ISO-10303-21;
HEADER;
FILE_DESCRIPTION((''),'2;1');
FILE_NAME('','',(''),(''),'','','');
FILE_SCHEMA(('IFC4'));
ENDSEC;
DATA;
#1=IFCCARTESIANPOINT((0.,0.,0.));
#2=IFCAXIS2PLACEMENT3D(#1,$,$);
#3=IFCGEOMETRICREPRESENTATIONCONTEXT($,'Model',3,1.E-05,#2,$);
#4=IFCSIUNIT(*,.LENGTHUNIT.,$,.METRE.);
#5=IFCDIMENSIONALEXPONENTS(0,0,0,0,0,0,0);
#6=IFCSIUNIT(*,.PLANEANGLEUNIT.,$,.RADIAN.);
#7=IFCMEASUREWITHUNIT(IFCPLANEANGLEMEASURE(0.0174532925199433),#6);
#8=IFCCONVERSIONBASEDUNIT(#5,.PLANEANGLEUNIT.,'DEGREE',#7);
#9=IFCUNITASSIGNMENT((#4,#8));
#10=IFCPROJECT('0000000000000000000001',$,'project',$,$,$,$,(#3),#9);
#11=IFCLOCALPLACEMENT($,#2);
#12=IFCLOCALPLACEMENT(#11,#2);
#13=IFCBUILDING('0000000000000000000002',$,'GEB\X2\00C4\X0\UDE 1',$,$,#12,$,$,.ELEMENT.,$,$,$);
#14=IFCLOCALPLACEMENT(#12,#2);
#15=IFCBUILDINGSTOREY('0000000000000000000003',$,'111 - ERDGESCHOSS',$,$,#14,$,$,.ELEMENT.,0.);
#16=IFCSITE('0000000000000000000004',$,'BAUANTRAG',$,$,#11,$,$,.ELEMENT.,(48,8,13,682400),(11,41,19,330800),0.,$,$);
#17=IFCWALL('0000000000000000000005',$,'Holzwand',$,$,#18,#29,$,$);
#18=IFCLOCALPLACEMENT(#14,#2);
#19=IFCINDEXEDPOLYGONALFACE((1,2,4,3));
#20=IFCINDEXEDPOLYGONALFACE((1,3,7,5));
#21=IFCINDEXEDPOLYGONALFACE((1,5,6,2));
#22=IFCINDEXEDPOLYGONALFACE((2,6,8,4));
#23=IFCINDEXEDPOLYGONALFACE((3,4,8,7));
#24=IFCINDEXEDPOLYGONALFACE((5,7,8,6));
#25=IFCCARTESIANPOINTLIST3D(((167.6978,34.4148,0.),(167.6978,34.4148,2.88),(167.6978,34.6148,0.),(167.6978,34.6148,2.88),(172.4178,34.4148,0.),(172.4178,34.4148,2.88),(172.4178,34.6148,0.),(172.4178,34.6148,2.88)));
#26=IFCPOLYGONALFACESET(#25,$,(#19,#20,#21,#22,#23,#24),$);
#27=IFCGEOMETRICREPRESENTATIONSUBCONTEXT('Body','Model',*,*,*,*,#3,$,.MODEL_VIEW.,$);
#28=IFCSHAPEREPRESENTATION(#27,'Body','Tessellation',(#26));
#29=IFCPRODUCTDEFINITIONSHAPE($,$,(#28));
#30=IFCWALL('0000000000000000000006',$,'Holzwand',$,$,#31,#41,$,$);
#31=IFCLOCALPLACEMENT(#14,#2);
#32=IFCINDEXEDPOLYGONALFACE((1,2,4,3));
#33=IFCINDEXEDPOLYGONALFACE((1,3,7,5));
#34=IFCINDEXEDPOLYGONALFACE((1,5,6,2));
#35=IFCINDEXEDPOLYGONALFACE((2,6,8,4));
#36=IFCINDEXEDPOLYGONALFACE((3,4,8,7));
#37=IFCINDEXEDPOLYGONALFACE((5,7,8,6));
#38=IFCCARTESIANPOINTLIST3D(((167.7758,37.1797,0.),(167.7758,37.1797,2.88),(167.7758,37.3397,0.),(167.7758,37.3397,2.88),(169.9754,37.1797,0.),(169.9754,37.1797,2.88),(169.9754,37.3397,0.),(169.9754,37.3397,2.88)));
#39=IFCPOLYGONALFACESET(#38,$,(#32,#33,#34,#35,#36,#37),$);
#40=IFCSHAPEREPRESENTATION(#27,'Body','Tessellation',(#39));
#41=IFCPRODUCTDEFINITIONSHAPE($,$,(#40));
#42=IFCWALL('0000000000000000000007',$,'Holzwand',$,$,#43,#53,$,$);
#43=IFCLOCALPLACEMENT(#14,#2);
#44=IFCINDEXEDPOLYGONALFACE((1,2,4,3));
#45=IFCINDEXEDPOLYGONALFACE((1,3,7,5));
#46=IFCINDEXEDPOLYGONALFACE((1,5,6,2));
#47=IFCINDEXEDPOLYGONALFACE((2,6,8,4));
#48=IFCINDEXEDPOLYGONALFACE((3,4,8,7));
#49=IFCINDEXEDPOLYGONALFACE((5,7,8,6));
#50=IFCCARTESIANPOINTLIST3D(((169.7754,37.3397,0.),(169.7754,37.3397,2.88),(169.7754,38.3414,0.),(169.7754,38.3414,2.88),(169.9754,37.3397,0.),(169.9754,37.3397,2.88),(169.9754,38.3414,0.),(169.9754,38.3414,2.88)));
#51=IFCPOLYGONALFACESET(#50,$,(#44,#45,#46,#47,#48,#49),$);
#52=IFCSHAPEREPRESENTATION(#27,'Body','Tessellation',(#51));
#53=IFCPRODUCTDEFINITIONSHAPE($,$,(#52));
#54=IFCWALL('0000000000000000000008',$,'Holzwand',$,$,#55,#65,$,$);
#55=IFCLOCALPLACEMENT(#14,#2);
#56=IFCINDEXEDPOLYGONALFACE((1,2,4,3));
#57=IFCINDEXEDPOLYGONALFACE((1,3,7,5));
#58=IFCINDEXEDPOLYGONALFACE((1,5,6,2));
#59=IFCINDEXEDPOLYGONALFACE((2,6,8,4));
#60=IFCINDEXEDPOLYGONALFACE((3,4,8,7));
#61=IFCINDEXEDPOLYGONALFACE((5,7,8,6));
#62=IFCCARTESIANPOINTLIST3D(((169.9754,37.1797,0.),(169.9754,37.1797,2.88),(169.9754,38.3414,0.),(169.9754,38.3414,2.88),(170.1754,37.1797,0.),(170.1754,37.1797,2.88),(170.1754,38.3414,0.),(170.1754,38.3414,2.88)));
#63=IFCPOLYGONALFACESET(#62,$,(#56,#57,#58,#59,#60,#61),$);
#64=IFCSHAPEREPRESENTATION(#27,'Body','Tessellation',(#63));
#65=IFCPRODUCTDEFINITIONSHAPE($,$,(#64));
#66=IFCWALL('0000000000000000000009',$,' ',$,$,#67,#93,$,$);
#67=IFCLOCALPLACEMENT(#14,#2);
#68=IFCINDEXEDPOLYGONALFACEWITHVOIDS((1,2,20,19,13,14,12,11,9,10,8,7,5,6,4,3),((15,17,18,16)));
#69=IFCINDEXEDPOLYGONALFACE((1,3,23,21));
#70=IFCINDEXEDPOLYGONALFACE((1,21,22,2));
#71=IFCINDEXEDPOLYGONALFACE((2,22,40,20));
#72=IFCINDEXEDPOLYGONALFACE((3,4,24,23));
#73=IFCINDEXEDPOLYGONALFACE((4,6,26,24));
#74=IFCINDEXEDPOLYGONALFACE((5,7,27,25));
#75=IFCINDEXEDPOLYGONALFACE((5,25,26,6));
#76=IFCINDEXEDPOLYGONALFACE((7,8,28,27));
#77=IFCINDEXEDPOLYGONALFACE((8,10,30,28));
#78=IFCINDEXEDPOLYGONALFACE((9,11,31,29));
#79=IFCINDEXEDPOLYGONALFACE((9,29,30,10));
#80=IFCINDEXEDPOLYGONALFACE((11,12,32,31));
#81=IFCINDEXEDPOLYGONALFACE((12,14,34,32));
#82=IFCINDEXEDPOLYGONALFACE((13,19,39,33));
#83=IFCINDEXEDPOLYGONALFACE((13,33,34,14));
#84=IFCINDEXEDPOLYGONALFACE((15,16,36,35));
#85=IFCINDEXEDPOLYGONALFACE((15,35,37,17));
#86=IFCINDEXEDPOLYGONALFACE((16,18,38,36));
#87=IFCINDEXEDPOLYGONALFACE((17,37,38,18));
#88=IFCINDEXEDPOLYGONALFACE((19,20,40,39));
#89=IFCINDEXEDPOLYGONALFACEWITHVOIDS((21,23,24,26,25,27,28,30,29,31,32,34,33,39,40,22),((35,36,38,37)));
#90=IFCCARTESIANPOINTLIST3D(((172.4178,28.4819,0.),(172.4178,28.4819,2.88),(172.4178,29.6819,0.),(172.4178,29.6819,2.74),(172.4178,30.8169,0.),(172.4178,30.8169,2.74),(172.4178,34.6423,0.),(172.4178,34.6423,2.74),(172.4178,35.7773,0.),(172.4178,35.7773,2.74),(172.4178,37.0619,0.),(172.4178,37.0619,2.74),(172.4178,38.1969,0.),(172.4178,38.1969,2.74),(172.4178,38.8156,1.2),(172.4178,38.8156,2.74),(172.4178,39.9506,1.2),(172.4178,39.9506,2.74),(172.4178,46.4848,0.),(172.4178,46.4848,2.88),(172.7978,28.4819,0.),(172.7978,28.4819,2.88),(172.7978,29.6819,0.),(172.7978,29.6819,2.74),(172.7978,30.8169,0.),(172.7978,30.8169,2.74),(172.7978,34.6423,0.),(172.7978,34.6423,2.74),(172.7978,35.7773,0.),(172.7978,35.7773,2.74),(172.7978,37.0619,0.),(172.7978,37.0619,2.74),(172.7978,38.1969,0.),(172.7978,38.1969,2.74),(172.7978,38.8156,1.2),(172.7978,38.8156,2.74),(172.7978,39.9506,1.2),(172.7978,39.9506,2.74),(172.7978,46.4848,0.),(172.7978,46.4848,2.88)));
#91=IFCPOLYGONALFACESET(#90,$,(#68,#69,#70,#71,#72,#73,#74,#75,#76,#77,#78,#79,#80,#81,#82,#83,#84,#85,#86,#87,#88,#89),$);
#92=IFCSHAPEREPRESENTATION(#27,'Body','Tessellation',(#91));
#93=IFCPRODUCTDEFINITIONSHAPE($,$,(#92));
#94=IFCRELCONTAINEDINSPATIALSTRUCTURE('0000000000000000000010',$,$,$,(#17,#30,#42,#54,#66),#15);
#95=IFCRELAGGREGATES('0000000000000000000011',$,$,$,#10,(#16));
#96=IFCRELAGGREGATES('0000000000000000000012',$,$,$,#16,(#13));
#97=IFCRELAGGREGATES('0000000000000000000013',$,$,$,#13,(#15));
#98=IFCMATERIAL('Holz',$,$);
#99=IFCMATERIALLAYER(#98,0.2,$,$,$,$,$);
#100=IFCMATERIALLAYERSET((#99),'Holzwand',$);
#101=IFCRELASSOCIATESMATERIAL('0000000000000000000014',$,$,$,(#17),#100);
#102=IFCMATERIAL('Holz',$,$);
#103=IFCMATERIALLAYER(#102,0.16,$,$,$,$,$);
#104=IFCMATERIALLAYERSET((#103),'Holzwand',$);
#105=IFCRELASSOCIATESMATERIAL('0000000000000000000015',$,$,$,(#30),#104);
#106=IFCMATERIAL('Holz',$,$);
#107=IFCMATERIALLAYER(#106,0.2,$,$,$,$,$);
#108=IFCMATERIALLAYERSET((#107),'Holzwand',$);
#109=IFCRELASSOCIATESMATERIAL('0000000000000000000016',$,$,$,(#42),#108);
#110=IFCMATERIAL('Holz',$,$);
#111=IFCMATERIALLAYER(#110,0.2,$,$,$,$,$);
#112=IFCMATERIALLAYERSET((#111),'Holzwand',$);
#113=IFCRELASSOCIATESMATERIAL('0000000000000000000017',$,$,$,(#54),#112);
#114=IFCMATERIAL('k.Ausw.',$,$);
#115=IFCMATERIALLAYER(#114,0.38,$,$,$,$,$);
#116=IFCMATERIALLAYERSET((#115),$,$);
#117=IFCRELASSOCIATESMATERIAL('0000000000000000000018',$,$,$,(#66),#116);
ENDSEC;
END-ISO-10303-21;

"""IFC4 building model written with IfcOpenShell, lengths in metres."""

from ifc_helpers import new_model, entity, si_unit, converted_unit, frame, frame_2d, origin, origin_with_axes, place, context, subcontext, project, spatial, polyline, rectangle, outline, extrude, material, layer, layer_set, layer_usage, element, save


model = new_model("IFC4")

# Units and contexts
model_context = context("Model", 3, precision=1e-05, world=origin())
body_context = subcontext(model_context, "Body", "Model", "MODEL_VIEW")
ifc_project = project(units=[si_unit("LENGTHUNIT", "METRE"), converted_unit("PLANEANGLEUNIT", "DEGREE", entity("IfcPlaneAngleMeasure", 0.0174532925199433), si_unit("PLANEANGLEUNIT", "RADIAN"), dimensions=[0, 0, 0, 0, 0, 0, 0])], contexts=[model_context])

# Site, building, storey
site_placement = place(None, origin())
site = spatial("IfcSite", under=ifc_project, at=site_placement, Name="BAUANTRAG", CompositionType="ELEMENT", RefLatitude=(48, 8, 13, 682400), RefLongitude=(11, 41, 19, 330800), RefElevation=0.0)
building_placement = place(site_placement, origin())
building = spatial("IfcBuilding", under=site, at=building_placement, Name="GEBÄUDE 1", CompositionType="ELEMENT")
storey_placement = place(building_placement, origin())
storey = spatial("IfcBuildingStorey", under=building, at=storey_placement, Name="111 - ERDGESCHOSS", CompositionType="ELEMENT", Elevation=0.0)

# Walls
ifc_material_1 = material(Name="Holz")
ifc_layer_1 = layer(ifc_material_1, 0.2)
ifc_layer_set_1 = layer_set([ifc_layer_1], Name="Holzwand")
ifc_layer_usage_1 = layer_usage(ifc_layer_set_1, "AXIS2", "POSITIVE", 0.0)
wall_1_placement = place(storey_placement, frame((167.6978, 34.4148, 0.0)))
element("IfcWall", 1, at=wall_1_placement, inside=storey, material=ifc_layer_usage_1, Name="Holzwand", context=body_context, shape_type="SweptSolid", body=[
    extrude(rectangle(XDim=4.72, YDim=0.2, at=frame_2d((2.36, 0.1), x_axis=(1.0, 0.0))), origin_with_axes(), (0.0, 0.0, 1.0), 2.88),
])
ifc_material_2 = material(Name="Holz")
ifc_layer_2 = layer(ifc_material_2, 0.16)
ifc_layer_set_2 = layer_set([ifc_layer_2], Name="Holzwand")
ifc_layer_usage_2 = layer_usage(ifc_layer_set_2, "AXIS2", "POSITIVE", 0.0)
wall_2_placement = place(storey_placement, frame((169.9754, 37.3397, 0.0), z_axis=(0.0, 0.0, 1.0), x_axis=(-1.0, 0.0, 0.0)))
element("IfcWall", 2, at=wall_2_placement, inside=storey, material=ifc_layer_usage_2, Name="Holzwand", context=body_context, shape_type="SweptSolid", body=[
    extrude(rectangle(XDim=2.1997, YDim=0.16, at=frame_2d((1.0998, 0.08), x_axis=(1.0, 0.0))), origin_with_axes(), (0.0, 0.0, 1.0), 2.88),
])
ifc_material_3 = material(Name="Holz")
ifc_layer_3 = layer(ifc_material_3, 0.2)
ifc_layer_set_3 = layer_set([ifc_layer_3], Name="Holzwand")
ifc_layer_usage_3 = layer_usage(ifc_layer_set_3, "AXIS2", "POSITIVE", 0.0)
wall_3_placement = place(storey_placement, frame((169.9754, 37.3397, 0.0), z_axis=(0.0, 0.0, 1.0), x_axis=(0.0, 1.0, 0.0)))
element("IfcWall", 3, at=wall_3_placement, inside=storey, material=ifc_layer_usage_3, Name="Holzwand", context=body_context, shape_type="SweptSolid", body=[
    extrude(rectangle(XDim=1.0017, YDim=0.2, at=frame_2d((0.5008, 0.1), x_axis=(1.0, 0.0))), origin_with_axes(), (0.0, 0.0, 1.0), 2.88),
])
ifc_material_4 = material(Name="Holz")
ifc_layer_4 = layer(ifc_material_4, 0.2)
ifc_layer_set_4 = layer_set([ifc_layer_4], Name="Holzwand")
ifc_layer_usage_4 = layer_usage(ifc_layer_set_4, "AXIS2", "POSITIVE", 0.0)
wall_4_placement = place(storey_placement, frame((170.1754, 37.1797, 0.0), z_axis=(0.0, 0.0, 1.0), x_axis=(0.0, 1.0, 0.0)))
element("IfcWall", 4, at=wall_4_placement, inside=storey, material=ifc_layer_usage_4, Name="Holzwand", context=body_context, shape_type="SweptSolid", body=[
    extrude(rectangle(XDim=1.1617, YDim=0.2, at=frame_2d((0.5808, 0.1), x_axis=(1.0, 0.0))), origin_with_axes(), (0.0, 0.0, 1.0), 2.88),
])

# Wall, openings
ifc_material_5 = material(Name="k.Ausw.")
ifc_layer_5 = layer(ifc_material_5, 0.38)
ifc_layer_set_5 = layer_set([ifc_layer_5])
ifc_layer_usage_5 = layer_usage(ifc_layer_set_5, "AXIS2", "POSITIVE", 0.0)
wall_5_placement = place(storey_placement, frame((172.7978, 28.4819, 0.0), z_axis=(0.0, 0.0, 1.0), x_axis=(0.0, 1.0, 0.0)))
wall_5 = element("IfcWall", 5, at=wall_5_placement, inside=storey, material=ifc_layer_usage_5, Name=" ", context=body_context, shape_type="SweptSolid", body=[
    extrude(rectangle(XDim=18.0029, YDim=0.38, at=frame_2d((9.0014, 0.19), x_axis=(1.0, 0.0))), origin_with_axes(), (0.0, 0.0, 1.0), 2.88),
])
opening_1_placement = place(wall_5_placement, frame((10.3337, 0.0, 1.2), z_axis=(0.0, 1.0, 0.0), x_axis=(0.0, 0.0, 1.0)))
element("IfcOpeningElement", 6, at=opening_1_placement, cuts=wall_5, ObjectType="Opening", context=body_context, shape_type="SweptSolid", body=[
    extrude(outline(polyline([(0.0, 1.135), (1.54, 1.135), (1.54, 0.0), (0.0, 0.0), (0.0, 1.135)])), origin_with_axes(), (0.0, 0.0, 1.0), 0.38),
])
opening_2_placement = place(wall_5_placement, frame((8.58, 0.0, 0.0), z_axis=(0.0, 1.0, 0.0), x_axis=(0.0, 0.0, 1.0)))
element("IfcOpeningElement", 7, at=opening_2_placement, cuts=wall_5, ObjectType="Opening", context=body_context, shape_type="SweptSolid", body=[
    extrude(outline(polyline([(0.0, 1.135), (2.74, 1.135), (2.74, 0.0), (0.0, 0.0), (0.0, 1.135)])), origin_with_axes(), (0.0, 0.0, 1.0), 0.38),
])
opening_3_placement = place(wall_5_placement, frame((6.1604, 0.0, 0.0), z_axis=(0.0, 1.0, 0.0), x_axis=(0.0, 0.0, 1.0)))
element("IfcOpeningElement", 8, at=opening_3_placement, cuts=wall_5, ObjectType="Opening", context=body_context, shape_type="SweptSolid", body=[
    extrude(outline(polyline([(0.0, 1.135), (2.74, 1.135), (2.74, 0.0), (0.0, 0.0), (0.0, 1.135)])), origin_with_axes(), (0.0, 0.0, 1.0), 0.38),
])
opening_4_placement = place(wall_5_placement, frame((1.2, 0.0, 0.0), z_axis=(0.0, 1.0, 0.0), x_axis=(0.0, 0.0, 1.0)))
element("IfcOpeningElement", 9, at=opening_4_placement, cuts=wall_5, ObjectType="Opening", context=body_context, shape_type="SweptSolid", body=[
    extrude(outline(polyline([(0.0, 1.135), (2.74, 1.135), (2.74, 0.0), (0.0, 0.0), (0.0, 1.135)])), origin_with_axes(), (0.0, 0.0, 1.0), 0.38),
])

save(model, "model.ifc")
